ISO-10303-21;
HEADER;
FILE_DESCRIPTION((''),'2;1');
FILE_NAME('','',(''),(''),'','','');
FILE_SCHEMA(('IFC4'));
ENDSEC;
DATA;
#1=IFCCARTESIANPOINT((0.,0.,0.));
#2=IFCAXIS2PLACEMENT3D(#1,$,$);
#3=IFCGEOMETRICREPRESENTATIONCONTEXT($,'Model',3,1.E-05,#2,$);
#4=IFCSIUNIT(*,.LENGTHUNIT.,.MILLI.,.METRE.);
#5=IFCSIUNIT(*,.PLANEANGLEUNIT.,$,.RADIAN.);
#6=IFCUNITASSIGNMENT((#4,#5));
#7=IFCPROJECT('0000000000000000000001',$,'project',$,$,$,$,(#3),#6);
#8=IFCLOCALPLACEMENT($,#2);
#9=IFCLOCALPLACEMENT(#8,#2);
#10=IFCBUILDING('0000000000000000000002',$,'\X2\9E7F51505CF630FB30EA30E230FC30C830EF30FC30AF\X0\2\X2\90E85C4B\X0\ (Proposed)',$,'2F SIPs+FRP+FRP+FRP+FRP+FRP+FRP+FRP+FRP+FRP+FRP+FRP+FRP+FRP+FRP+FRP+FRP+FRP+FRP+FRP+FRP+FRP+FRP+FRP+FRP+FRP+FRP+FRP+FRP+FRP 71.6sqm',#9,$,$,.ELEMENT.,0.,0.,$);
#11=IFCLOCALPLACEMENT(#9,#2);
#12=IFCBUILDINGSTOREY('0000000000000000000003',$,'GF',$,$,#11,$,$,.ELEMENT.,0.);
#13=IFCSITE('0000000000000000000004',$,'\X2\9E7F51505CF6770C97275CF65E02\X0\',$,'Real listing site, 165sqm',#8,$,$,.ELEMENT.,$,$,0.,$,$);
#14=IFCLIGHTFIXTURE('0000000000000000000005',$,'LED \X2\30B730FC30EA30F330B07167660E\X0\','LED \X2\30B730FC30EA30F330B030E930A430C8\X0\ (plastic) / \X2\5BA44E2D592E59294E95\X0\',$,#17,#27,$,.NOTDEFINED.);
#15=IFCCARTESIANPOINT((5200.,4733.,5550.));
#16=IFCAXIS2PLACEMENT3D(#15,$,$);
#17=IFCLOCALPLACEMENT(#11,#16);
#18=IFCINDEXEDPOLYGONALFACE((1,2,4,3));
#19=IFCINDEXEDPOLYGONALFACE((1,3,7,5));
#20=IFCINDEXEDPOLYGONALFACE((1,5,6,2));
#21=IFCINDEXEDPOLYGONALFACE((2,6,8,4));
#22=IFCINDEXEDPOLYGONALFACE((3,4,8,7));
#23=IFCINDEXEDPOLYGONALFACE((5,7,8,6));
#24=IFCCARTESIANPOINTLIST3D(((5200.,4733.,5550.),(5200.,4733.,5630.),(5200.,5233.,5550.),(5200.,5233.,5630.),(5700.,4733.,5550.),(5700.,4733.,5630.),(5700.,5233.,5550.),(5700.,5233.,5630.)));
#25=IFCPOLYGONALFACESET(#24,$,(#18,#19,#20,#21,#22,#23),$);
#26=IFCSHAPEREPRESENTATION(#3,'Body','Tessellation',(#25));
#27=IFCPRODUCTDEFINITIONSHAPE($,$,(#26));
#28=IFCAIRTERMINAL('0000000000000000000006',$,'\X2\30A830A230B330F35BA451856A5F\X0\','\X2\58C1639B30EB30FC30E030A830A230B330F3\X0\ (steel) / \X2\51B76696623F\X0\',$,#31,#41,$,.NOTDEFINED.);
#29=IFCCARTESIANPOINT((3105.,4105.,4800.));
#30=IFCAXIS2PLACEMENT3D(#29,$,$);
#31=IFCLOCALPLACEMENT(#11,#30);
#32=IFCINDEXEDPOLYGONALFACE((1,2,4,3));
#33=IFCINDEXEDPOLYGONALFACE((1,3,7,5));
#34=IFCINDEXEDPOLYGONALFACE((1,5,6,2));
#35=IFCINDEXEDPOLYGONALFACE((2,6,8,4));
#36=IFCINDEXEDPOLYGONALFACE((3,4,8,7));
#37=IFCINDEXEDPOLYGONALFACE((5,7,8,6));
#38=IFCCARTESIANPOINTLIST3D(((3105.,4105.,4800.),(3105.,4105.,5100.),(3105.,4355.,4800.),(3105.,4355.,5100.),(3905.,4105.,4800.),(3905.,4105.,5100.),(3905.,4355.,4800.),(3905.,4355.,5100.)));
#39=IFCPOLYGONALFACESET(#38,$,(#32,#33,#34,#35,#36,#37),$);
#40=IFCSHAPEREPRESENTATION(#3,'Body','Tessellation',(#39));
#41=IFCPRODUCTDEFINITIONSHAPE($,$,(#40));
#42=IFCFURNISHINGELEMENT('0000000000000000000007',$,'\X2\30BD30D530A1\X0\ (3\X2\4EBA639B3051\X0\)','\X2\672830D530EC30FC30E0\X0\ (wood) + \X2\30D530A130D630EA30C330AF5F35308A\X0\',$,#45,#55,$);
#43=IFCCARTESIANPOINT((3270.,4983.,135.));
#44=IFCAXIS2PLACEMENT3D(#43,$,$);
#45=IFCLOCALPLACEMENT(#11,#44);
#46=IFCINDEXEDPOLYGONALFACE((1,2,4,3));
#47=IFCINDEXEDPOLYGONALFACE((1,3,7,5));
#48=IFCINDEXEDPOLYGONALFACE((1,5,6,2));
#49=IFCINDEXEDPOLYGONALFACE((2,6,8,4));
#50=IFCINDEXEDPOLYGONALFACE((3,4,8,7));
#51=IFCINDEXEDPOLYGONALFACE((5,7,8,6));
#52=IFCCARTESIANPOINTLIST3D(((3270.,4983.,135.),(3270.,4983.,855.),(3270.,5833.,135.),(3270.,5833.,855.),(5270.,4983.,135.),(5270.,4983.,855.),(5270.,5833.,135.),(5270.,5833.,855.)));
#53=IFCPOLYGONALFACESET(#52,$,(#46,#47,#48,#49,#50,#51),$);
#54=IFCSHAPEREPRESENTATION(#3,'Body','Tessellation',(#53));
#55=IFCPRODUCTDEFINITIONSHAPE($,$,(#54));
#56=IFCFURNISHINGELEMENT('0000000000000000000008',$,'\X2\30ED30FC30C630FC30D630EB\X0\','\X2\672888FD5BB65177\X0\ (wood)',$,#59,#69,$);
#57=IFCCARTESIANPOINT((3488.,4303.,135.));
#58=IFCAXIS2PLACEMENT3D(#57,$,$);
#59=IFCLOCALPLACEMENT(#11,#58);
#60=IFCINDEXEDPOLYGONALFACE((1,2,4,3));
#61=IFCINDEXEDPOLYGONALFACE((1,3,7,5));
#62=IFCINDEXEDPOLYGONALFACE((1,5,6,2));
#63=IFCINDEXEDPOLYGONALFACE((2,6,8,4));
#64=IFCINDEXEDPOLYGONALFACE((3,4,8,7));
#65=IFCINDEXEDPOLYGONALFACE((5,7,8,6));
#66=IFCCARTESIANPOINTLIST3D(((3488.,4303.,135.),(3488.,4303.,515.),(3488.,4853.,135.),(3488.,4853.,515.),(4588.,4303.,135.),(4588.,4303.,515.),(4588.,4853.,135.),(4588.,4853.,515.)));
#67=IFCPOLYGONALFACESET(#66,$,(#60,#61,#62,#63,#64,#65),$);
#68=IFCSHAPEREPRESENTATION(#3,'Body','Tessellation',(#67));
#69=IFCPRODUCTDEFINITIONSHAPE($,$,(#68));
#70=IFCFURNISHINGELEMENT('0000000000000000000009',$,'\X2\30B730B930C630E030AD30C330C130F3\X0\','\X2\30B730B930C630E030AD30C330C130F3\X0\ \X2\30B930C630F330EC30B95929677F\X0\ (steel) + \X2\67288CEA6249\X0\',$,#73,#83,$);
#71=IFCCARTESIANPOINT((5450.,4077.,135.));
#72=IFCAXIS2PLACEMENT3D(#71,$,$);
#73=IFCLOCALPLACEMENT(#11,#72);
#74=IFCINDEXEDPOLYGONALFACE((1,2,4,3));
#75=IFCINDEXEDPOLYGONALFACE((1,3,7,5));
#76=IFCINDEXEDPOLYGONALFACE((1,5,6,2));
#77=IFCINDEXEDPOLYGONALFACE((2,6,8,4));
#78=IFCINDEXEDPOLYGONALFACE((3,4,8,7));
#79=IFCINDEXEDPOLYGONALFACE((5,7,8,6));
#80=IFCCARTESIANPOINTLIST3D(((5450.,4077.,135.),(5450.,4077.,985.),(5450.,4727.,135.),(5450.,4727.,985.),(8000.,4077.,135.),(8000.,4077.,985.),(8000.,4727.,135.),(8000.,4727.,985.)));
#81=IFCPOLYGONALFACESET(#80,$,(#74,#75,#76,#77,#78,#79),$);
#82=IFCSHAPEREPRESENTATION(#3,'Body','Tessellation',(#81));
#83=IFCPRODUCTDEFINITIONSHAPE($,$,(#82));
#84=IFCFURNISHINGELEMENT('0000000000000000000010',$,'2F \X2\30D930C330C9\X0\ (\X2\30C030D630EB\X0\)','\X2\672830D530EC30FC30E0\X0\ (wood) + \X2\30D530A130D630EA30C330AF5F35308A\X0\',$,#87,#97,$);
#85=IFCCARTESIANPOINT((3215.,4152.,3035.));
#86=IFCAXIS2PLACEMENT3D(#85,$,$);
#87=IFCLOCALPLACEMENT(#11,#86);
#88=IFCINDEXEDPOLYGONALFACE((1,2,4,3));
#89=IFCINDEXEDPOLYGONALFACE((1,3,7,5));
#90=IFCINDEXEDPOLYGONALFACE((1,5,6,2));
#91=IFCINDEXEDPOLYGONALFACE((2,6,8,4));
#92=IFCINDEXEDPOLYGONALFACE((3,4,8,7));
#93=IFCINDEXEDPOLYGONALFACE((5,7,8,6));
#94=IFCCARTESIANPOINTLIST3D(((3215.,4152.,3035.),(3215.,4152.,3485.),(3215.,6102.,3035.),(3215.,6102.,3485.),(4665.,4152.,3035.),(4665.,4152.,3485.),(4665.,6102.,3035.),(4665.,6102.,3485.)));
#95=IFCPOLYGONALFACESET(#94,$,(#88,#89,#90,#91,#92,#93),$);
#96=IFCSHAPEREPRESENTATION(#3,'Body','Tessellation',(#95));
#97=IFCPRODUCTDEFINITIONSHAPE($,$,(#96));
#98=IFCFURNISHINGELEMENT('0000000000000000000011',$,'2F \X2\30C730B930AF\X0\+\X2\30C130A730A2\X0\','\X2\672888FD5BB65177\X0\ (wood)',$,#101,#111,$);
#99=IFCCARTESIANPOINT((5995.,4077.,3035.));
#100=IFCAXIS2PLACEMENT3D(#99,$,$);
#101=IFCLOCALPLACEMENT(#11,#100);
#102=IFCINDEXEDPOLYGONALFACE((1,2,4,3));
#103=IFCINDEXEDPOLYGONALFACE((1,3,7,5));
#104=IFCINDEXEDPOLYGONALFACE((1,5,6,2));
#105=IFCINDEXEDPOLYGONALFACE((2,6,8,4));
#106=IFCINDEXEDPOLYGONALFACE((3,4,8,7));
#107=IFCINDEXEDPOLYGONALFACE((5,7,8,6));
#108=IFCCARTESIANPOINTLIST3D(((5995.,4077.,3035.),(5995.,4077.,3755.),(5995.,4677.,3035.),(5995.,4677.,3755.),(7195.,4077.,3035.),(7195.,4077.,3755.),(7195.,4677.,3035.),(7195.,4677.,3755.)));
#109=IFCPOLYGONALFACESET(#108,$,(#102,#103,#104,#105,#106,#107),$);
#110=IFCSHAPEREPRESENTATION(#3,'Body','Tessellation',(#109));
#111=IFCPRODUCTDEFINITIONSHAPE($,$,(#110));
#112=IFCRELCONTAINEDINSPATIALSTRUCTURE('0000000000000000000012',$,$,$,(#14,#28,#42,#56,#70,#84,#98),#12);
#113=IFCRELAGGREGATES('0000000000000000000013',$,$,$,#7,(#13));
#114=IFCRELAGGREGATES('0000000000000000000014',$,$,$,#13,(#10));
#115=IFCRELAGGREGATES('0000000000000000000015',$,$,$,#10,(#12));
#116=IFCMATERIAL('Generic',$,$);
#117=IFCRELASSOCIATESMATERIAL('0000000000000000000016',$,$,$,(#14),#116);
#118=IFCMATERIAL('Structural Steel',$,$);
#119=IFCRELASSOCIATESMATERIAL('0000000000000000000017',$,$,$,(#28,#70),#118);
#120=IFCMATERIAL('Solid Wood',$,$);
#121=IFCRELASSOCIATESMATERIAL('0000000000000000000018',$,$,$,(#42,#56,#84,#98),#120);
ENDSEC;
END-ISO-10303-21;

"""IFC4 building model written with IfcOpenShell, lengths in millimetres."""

from ifc_helpers import new_model, si_unit, frame, frame_2d, origin, place, context, project, spatial, rectangle, extrude, material, element, save


model = new_model("IFC4")

# Units and contexts
model_context = context("Model", 3, precision=1e-05, world=origin())
ifc_project = project(units=[si_unit("LENGTHUNIT", "METRE", prefix="MILLI"), si_unit("PLANEANGLEUNIT", "RADIAN")], contexts=[model_context])

# Site, building, storey
site_placement = place(None, origin())
site = spatial("IfcSite", under=ifc_project, at=site_placement, Name="鹿児島県霧島市", ObjectType="Real listing site, 165sqm", CompositionType="ELEMENT", RefElevation=0.0)
building_placement = place(site_placement, origin())
building = spatial("IfcBuilding", under=site, at=building_placement, Name="鹿児島・リモートワーク2部屋 (Proposed)", ObjectType="2F SIPs+FRP+FRP+FRP+FRP+FRP+FRP+FRP+FRP+FRP+FRP+FRP+FRP+FRP+FRP+FRP+FRP+FRP+FRP+FRP+FRP+FRP+FRP+FRP+FRP+FRP+FRP+FRP+FRP+FRP 71.6sqm", CompositionType="ELEMENT", ElevationOfRefHeight=0.0, ElevationOfTerrain=0.0)
storey_placement = place(building_placement, origin())
storey = spatial("IfcBuildingStorey", under=building, at=storey_placement, Name="GF", CompositionType="ELEMENT", Elevation=0.0)

# Shared definitions
ifc_material_1 = material(Name="Solid Wood")

# Shared definitions
ifc_material_2 = material(Name="Generic")

# Shared definitions
ifc_material_3 = material(Name="Structural Steel")

# Light fixture
light_fixture_1_placement = place(storey_placement, frame((5200.0, 4733.0, 5550.0)))
element("IfcLightFixture", 1, at=light_fixture_1_placement, inside=storey, material=ifc_material_2, Name="LED シーリング照明", Description="LED シーリングライト (plastic) / 室中央天井", PredefinedType="NOTDEFINED", context=model_context, shape_type="SweptSolid", body=[
    extrude(rectangle(XDim=500.0, YDim=500.0, at=frame_2d((250.0, 250.0))), frame((5200.0, 4733.0, 5550.0)), (0.0, 0.0, 1.0), 80.0),
])

# Air terminal
air_terminal_placement = place(storey_placement, frame((3105.0, 4105.0, 4800.0)))
element("IfcAirTerminal", 2, at=air_terminal_placement, inside=storey, material=ifc_material_3, Name="エアコン室内機", Description="壁掛ルームエアコン (steel) / 冷暖房", PredefinedType="NOTDEFINED", context=model_context, shape_type="SweptSolid", body=[
    extrude(rectangle(XDim=800.0, YDim=250.0, at=frame_2d((400.0, 125.0))), frame((3105.0, 4105.0, 4800.0)), (0.0, 0.0, 1.0), 300.0),
])

# Furnishing elements
furnishing_1_placement = place(storey_placement, frame((3270.0, 4983.0, 135.0)))
element("IfcFurnishingElement", 3, at=furnishing_1_placement, inside=storey, material=ifc_material_1, Name="ソファ (3人掛け)", Description="木フレーム (wood) + ファブリック張り", context=model_context, shape_type="SweptSolid", body=[
    extrude(rectangle(XDim=2000.0, YDim=850.0, at=frame_2d((1000.0, 425.0))), frame((3270.0, 4983.0, 135.0)), (0.0, 0.0, 1.0), 720.0),
])
furnishing_2_placement = place(storey_placement, frame((3488.0, 4303.0, 135.0)))
element("IfcFurnishingElement", 4, at=furnishing_2_placement, inside=storey, material=ifc_material_1, Name="ローテーブル", Description="木製家具 (wood)", context=model_context, shape_type="SweptSolid", body=[
    extrude(rectangle(XDim=1100.0, YDim=550.0, at=frame_2d((550.0, 275.0))), frame((3488.0, 4303.0, 135.0)), (0.0, 0.0, 1.0), 380.0),
])
furnishing_3_placement = place(storey_placement, frame((5450.0, 4077.0, 135.0)))
element("IfcFurnishingElement", 5, at=furnishing_3_placement, inside=storey, material=ifc_material_3, Name="システムキッチン", Description="システムキッチン ステンレス天板 (steel) + 木質扉", context=model_context, shape_type="SweptSolid", body=[
    extrude(rectangle(XDim=2550.0, YDim=650.0, at=frame_2d((1275.0, 325.0))), frame((5450.0, 4077.0, 135.0)), (0.0, 0.0, 1.0), 850.0),
])
furnishing_4_placement = place(storey_placement, frame((3215.0, 4152.0, 3035.0)))
element("IfcFurnishingElement", 6, at=furnishing_4_placement, inside=storey, material=ifc_material_1, Name="2F ベッド (ダブル)", Description="木フレーム (wood) + ファブリック張り", context=model_context, shape_type="SweptSolid", body=[
    extrude(rectangle(XDim=1450.0, YDim=1950.0, at=frame_2d((725.0, 975.0))), frame((3215.0, 4152.0, 3035.0)), (0.0, 0.0, 1.0), 450.0),
])
furnishing_5_placement = place(storey_placement, frame((5995.0, 4077.0, 3035.0)))
element("IfcFurnishingElement", 7, at=furnishing_5_placement, inside=storey, material=ifc_material_1, Name="2F デスク+チェア", Description="木製家具 (wood)", context=model_context, shape_type="SweptSolid", body=[
    extrude(rectangle(XDim=1200.0, YDim=600.0, at=frame_2d((600.0, 300.0))), frame((5995.0, 4077.0, 3035.0)), (0.0, 0.0, 1.0), 720.0),
])

save(model, "model.ifc")
